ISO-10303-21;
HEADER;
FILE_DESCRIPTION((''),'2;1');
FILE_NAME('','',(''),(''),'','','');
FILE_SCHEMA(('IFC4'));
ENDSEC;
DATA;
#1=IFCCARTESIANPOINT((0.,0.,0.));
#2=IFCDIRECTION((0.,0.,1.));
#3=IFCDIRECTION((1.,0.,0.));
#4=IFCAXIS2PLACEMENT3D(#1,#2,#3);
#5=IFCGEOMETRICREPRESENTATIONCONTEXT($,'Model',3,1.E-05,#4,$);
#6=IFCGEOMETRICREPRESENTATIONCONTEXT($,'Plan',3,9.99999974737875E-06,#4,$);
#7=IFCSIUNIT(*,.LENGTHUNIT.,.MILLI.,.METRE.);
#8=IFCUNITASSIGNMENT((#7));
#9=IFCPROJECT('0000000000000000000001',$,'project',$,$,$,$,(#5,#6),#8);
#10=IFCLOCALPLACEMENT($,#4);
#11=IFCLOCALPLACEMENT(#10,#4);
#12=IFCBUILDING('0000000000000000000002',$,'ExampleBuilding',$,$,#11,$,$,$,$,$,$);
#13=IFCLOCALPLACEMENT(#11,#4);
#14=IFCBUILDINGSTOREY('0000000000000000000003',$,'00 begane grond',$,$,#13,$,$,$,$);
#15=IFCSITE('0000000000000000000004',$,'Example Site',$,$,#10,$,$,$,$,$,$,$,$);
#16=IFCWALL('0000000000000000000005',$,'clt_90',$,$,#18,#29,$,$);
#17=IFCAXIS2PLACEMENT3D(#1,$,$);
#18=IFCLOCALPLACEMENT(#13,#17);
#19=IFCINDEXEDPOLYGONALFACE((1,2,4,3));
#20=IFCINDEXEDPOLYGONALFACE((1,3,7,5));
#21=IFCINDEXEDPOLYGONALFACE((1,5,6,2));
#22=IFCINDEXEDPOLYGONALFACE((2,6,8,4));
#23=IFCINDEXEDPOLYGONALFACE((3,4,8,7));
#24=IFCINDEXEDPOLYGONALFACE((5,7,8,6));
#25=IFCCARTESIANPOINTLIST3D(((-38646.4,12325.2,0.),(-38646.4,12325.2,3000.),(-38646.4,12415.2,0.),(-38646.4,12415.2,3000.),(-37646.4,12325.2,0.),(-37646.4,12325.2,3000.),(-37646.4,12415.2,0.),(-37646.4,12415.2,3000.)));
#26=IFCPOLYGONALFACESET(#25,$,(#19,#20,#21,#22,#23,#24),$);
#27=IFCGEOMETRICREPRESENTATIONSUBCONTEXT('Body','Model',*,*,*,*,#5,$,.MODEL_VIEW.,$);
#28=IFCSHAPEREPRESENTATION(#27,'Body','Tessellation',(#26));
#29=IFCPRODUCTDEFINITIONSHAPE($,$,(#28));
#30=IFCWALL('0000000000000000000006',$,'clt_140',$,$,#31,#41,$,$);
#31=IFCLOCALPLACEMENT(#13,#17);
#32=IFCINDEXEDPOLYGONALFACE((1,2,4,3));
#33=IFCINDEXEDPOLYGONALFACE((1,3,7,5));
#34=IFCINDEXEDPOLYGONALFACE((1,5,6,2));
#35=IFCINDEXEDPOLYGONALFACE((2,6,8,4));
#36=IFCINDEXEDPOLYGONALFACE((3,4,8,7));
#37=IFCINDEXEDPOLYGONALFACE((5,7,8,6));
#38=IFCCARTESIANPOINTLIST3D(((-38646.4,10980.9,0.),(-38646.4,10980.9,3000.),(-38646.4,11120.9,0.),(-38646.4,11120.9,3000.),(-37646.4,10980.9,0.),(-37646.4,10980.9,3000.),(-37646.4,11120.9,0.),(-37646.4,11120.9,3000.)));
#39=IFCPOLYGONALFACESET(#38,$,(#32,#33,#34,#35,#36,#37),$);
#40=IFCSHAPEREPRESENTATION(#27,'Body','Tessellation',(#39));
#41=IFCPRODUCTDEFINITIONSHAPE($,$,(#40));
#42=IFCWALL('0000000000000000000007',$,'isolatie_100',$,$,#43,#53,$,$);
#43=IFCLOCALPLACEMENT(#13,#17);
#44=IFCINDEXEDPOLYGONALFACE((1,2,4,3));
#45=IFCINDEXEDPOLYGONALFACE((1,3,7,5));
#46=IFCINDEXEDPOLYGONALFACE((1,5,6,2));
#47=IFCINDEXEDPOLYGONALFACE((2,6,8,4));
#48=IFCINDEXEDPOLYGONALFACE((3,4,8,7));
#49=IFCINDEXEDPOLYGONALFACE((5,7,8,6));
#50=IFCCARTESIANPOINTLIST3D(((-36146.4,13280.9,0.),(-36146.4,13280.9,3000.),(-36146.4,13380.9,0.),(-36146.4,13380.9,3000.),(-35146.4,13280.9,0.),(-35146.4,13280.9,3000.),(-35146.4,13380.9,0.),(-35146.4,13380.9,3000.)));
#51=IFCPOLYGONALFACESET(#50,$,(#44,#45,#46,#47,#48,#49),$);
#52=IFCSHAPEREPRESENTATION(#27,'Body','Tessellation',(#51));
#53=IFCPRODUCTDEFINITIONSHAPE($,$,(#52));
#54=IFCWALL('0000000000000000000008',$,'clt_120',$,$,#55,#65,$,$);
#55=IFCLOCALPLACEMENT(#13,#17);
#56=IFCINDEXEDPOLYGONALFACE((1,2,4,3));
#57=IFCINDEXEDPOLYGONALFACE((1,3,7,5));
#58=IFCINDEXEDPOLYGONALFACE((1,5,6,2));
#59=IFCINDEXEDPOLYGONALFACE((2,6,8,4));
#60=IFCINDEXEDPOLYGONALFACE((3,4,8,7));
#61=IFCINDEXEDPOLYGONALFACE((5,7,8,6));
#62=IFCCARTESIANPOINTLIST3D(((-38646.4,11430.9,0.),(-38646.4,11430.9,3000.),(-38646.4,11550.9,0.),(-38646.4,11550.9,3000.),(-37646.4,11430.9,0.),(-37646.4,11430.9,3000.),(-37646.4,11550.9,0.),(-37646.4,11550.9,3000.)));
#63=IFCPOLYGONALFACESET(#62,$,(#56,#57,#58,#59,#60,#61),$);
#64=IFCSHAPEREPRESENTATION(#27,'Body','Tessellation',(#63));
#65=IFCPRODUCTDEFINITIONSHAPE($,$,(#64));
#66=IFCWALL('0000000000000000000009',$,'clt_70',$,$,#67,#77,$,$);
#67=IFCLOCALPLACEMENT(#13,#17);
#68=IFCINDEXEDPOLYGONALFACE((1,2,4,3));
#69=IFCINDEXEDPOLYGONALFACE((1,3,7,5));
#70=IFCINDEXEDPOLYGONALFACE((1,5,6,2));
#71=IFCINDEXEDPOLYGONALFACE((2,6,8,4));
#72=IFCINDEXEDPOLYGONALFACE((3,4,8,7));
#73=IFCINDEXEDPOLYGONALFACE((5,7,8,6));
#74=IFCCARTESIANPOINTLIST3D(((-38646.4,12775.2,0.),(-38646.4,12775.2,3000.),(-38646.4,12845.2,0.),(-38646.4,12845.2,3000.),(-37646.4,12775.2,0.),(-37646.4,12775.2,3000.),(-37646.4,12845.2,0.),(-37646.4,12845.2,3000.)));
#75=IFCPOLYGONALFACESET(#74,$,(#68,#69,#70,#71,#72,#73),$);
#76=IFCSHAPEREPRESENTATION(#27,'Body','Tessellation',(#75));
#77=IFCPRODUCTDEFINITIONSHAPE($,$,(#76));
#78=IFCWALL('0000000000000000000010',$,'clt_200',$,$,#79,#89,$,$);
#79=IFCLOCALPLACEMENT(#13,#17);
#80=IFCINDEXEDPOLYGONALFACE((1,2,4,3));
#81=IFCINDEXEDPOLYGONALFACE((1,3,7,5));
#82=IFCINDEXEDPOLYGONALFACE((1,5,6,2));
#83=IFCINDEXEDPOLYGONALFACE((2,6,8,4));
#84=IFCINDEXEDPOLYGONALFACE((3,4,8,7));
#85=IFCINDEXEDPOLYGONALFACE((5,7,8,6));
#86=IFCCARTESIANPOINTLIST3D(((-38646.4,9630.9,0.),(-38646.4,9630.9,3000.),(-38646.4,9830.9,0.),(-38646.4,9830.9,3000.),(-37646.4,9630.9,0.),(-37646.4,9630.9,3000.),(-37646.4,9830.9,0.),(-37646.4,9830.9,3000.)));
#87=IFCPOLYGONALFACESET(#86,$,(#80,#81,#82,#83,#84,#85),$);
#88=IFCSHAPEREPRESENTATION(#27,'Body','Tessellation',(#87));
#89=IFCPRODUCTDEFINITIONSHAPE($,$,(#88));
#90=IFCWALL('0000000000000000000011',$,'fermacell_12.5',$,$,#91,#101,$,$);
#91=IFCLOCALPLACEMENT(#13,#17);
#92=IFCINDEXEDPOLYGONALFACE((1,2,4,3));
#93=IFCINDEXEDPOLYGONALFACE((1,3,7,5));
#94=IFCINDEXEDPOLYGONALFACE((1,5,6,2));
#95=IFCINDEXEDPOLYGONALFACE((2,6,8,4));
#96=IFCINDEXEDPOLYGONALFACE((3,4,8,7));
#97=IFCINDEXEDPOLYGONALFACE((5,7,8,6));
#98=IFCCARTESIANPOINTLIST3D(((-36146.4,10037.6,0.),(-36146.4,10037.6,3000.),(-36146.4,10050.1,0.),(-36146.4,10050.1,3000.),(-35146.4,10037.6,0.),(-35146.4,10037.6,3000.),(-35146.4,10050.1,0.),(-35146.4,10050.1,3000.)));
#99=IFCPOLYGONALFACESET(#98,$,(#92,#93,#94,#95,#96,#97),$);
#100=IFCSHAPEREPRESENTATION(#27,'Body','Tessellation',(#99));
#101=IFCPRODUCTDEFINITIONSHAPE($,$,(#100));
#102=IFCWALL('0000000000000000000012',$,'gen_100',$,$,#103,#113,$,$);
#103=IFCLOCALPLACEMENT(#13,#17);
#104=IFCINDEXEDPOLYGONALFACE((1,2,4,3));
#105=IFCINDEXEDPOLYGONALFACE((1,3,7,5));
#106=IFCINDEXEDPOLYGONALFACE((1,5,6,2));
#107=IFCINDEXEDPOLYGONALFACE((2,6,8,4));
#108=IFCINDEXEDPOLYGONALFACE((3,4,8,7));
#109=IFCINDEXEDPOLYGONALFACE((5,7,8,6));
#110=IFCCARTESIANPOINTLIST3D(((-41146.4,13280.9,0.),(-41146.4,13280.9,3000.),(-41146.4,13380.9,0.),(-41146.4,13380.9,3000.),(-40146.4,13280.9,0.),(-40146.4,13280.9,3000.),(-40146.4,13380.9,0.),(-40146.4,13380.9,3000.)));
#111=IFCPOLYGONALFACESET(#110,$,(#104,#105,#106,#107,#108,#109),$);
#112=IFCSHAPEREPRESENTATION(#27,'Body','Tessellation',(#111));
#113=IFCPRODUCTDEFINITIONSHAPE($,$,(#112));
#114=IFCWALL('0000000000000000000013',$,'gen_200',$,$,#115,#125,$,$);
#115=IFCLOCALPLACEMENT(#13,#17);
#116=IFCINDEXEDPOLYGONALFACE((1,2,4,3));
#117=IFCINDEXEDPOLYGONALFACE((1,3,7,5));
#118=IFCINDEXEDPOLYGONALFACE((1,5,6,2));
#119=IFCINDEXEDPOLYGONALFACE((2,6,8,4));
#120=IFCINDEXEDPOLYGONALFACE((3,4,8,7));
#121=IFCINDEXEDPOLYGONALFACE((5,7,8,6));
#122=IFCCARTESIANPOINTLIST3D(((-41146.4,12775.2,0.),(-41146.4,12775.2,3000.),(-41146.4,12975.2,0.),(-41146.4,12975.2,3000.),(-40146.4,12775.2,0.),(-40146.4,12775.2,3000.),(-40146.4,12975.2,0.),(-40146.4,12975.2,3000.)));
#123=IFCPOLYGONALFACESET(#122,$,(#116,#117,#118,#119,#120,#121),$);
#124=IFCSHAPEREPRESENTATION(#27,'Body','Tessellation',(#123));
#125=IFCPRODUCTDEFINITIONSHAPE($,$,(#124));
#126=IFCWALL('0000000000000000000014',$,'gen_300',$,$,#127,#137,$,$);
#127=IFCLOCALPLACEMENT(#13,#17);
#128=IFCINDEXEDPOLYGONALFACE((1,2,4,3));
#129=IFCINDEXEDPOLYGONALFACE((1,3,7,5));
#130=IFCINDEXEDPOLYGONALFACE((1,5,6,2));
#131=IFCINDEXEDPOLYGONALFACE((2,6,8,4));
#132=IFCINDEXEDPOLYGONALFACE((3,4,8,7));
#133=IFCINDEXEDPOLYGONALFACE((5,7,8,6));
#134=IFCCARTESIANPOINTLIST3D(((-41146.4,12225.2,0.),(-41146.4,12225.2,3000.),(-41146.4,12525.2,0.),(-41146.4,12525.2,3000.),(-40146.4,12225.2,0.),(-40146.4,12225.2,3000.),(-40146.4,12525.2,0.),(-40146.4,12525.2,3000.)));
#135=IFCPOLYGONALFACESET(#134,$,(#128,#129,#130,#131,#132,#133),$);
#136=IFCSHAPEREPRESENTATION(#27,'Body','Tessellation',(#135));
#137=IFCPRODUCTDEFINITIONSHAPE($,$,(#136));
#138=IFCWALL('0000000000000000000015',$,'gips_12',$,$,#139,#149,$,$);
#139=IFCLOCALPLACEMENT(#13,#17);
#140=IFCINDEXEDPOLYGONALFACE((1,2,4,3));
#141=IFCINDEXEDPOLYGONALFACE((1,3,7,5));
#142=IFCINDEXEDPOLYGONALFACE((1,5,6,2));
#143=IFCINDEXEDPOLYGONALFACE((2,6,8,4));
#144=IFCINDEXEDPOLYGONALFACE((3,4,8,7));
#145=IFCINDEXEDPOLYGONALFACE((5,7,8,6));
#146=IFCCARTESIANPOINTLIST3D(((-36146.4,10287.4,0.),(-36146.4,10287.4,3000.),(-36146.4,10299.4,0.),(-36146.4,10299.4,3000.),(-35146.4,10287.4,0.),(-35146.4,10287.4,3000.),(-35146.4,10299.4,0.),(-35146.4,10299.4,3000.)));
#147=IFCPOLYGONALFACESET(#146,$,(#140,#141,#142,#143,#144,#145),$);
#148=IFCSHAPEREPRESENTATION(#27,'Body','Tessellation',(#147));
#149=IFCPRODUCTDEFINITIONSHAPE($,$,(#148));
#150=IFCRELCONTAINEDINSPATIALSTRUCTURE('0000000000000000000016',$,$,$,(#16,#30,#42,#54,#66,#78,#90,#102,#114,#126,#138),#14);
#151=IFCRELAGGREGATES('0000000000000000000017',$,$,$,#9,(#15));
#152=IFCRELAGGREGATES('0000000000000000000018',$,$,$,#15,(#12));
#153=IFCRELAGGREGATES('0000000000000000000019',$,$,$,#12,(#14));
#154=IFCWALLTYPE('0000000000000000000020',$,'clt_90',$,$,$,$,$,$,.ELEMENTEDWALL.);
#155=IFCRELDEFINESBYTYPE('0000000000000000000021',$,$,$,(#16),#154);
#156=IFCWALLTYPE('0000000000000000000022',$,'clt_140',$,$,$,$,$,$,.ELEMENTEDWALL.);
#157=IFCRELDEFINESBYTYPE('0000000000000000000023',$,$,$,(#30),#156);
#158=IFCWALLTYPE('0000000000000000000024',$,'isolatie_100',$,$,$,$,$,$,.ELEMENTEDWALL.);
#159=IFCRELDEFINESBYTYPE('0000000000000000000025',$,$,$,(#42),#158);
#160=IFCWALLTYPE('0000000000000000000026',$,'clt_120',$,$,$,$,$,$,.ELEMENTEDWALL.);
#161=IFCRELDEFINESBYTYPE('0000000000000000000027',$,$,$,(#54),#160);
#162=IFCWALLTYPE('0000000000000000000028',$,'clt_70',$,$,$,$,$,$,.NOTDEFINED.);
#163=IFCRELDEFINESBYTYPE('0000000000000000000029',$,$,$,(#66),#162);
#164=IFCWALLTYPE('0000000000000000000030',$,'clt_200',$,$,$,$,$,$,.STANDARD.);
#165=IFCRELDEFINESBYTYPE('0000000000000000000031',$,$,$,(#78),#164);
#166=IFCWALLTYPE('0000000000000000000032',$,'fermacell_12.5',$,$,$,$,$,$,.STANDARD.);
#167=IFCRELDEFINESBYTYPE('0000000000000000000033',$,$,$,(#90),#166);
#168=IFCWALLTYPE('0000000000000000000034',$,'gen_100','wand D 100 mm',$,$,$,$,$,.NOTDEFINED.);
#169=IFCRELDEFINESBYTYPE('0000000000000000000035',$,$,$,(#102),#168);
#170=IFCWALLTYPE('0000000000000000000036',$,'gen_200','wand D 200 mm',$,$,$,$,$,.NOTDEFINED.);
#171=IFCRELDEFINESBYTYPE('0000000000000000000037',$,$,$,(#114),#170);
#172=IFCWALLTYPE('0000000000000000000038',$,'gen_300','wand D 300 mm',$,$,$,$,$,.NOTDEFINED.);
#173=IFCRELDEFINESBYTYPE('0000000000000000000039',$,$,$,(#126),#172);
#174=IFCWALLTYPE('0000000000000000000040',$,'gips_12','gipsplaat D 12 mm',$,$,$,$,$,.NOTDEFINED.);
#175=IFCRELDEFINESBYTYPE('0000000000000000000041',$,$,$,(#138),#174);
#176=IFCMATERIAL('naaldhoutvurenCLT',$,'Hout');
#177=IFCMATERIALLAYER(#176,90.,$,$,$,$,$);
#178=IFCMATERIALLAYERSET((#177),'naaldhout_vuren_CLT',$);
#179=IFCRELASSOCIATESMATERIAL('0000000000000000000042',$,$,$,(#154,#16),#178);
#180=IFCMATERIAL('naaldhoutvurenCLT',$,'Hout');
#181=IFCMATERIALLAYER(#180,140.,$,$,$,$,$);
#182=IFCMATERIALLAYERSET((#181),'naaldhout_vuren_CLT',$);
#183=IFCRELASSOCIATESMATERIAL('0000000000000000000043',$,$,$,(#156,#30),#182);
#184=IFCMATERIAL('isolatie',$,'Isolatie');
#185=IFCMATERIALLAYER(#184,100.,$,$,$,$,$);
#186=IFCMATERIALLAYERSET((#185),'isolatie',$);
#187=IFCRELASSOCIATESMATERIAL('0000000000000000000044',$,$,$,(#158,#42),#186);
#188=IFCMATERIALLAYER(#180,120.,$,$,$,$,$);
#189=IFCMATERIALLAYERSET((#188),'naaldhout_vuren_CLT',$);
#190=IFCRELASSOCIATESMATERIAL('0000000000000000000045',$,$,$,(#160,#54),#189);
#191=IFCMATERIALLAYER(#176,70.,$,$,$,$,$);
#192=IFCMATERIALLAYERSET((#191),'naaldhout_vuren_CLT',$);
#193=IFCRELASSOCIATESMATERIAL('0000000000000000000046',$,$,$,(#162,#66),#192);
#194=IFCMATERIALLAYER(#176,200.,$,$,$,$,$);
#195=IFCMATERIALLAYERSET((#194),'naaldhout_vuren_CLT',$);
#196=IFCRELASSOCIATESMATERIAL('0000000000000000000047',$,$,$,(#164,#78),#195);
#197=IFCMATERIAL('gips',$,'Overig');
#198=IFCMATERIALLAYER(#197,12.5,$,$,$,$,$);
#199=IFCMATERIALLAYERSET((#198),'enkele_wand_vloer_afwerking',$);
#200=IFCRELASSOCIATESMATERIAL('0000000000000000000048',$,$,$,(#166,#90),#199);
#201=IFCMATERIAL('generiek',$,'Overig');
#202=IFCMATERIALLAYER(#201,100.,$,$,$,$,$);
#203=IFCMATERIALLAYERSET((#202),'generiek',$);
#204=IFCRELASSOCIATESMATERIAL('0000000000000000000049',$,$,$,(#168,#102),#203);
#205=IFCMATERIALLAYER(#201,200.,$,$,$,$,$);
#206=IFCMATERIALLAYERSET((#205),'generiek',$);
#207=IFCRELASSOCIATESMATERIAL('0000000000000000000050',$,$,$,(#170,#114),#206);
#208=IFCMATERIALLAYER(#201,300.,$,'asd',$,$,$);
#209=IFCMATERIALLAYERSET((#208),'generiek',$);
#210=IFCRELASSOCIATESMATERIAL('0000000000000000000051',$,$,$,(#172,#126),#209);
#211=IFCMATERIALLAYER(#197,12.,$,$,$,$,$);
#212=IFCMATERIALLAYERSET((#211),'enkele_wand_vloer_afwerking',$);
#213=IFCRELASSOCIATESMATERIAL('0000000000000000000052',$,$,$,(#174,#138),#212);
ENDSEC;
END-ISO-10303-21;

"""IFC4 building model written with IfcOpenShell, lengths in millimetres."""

from ifc_helpers import new_model, si_unit, frame, origin_with_axes, place, context, subcontext, project, spatial, indexed_curve, outline, extrude, material, layer, layer_set, layer_usage, type_object, element, save


model = new_model("IFC4")

# Units and contexts
model_context = context("Model", 3, precision=1e-05, world=origin_with_axes())
plan_context = context("Plan", 3, precision=9.99999974737875e-06, world=origin_with_axes())
body_context = subcontext(model_context, "Body", "Model", "MODEL_VIEW")
ifc_project = project(units=[si_unit("LENGTHUNIT", "METRE", prefix="MILLI")], contexts=[model_context, plan_context])

# Site, building, storey
site_placement = place(None, frame((0.0, 0.0, 0.0), z_axis=(0.0, 0.0, 1.0), x_axis=(1.0, 0.0, 0.0)))
site = spatial("IfcSite", under=ifc_project, at=site_placement, Name="Example Site")
building_placement = place(site_placement, frame((0.0, 0.0, 0.0), z_axis=(0.0, 0.0, 1.0), x_axis=(1.0, 0.0, 0.0)))
building = spatial("IfcBuilding", under=site, at=building_placement, Name="ExampleBuilding")
storey_placement = place(building_placement, frame((0.0, 0.0, 0.0), z_axis=(0.0, 0.0, 1.0), x_axis=(1.0, 0.0, 0.0)))
storey = spatial("IfcBuildingStorey", under=building, at=storey_placement, Name="00 begane grond")

# Walls
ifc_material_1 = material(Name="naaldhoutvurenCLT", Category="Hout")
ifc_layer_1 = layer(ifc_material_1, 90.0)
ifc_layer_set_1 = layer_set([ifc_layer_1], Name="naaldhout_vuren_CLT")
ifc_layer_usage_1 = layer_usage(ifc_layer_set_1, "AXIS2", "POSITIVE", 0.0)
wall_type_1 = type_object("IfcWallType", Name="clt_90", PredefinedType="ELEMENTEDWALL", material=ifc_layer_set_1)
wall_1_placement = place(storey_placement, frame((-38646.4, 12325.2, 0.0), z_axis=(0.0, 0.0, 1.0), x_axis=(1.0, 0.0, 0.0)))
element("IfcWall", 1, at=wall_1_placement, inside=storey, type_object=wall_type_1, material=ifc_layer_usage_1, Name="clt_90", context=body_context, shape_type="SweptSolid", body=[
    extrude(outline(indexed_curve([(0.0, 0.0), (0.0, 90.0), (1000.0, 90.0), (1000.0, 0.0), (0.0, 0.0)], self_intersect=False)), origin_with_axes(), (0.0, 0.0, 1.0), 3000.0),
])
ifc_material_2 = material(Name="naaldhoutvurenCLT", Category="Hout")
ifc_layer_2 = layer(ifc_material_2, 140.0)
ifc_layer_set_2 = layer_set([ifc_layer_2], Name="naaldhout_vuren_CLT")
ifc_layer_usage_2 = layer_usage(ifc_layer_set_2, "AXIS2", "POSITIVE", 0.0)
wall_type_2 = type_object("IfcWallType", Name="clt_140", PredefinedType="ELEMENTEDWALL", material=ifc_layer_set_2)
wall_2_placement = place(storey_placement, frame((-38646.4, 10980.9, 0.0), z_axis=(0.0, 0.0, 1.0), x_axis=(1.0, 0.0, 0.0)))
element("IfcWall", 2, at=wall_2_placement, inside=storey, type_object=wall_type_2, material=ifc_layer_usage_2, Name="clt_140", context=body_context, shape_type="SweptSolid", body=[
    extrude(outline(indexed_curve([(0.0, 0.0), (0.0, 140.0), (1000.0, 140.0), (1000.0, 0.0), (0.0, 0.0)], self_intersect=False)), origin_with_axes(), (0.0, 0.0, 1.0), 3000.0),
])
ifc_material_3 = material(Name="isolatie", Category="Isolatie")
ifc_layer_3 = layer(ifc_material_3, 100.0)
ifc_layer_set_3 = layer_set([ifc_layer_3], Name="isolatie")
ifc_layer_usage_3 = layer_usage(ifc_layer_set_3, "AXIS2", "POSITIVE", 0.0)
wall_type_3 = type_object("IfcWallType", Name="isolatie_100", PredefinedType="ELEMENTEDWALL", material=ifc_layer_set_3)
wall_3_placement = place(storey_placement, frame((-36146.4, 13280.9, 0.0), z_axis=(0.0, 0.0, 1.0), x_axis=(1.0, 0.0, 0.0)))
element("IfcWall", 3, at=wall_3_placement, inside=storey, type_object=wall_type_3, material=ifc_layer_usage_3, Name="isolatie_100", context=body_context, shape_type="SweptSolid", body=[
    extrude(outline(indexed_curve([(0.0, 0.0), (0.0, 100.0), (1000.0, 100.0), (1000.0, 0.0), (0.0, 0.0)], self_intersect=False)), origin_with_axes(), (0.0, 0.0, 1.0), 3000.0),
])
ifc_layer_4 = layer(ifc_material_2, 120.0)
ifc_layer_set_4 = layer_set([ifc_layer_4], Name="naaldhout_vuren_CLT")
ifc_layer_usage_4 = layer_usage(ifc_layer_set_4, "AXIS2", "POSITIVE", 0.0)
wall_type_4 = type_object("IfcWallType", Name="clt_120", PredefinedType="ELEMENTEDWALL", material=ifc_layer_set_4)
wall_4_placement = place(storey_placement, frame((-38646.4, 11430.9, 0.0), z_axis=(0.0, 0.0, 1.0), x_axis=(1.0, 0.0, 0.0)))
element("IfcWall", 4, at=wall_4_placement, inside=storey, type_object=wall_type_4, material=ifc_layer_usage_4, Name="clt_120", context=body_context, shape_type="SweptSolid", body=[
    extrude(outline(indexed_curve([(0.0, 0.0), (0.0, 120.0), (1000.0, 120.0), (1000.0, 0.0), (0.0, 0.0)], self_intersect=False)), origin_with_axes(), (0.0, 0.0, 1.0), 3000.0),
])
ifc_layer_5 = layer(ifc_material_1, 70.0)
ifc_layer_set_5 = layer_set([ifc_layer_5], Name="naaldhout_vuren_CLT")
ifc_layer_usage_5 = layer_usage(ifc_layer_set_5, "AXIS2", "POSITIVE", 0.0)
wall_type_5 = type_object("IfcWallType", Name="clt_70", PredefinedType="NOTDEFINED", material=ifc_layer_set_5)
wall_5_placement = place(storey_placement, frame((-38646.4, 12775.2, 0.0), z_axis=(0.0, 0.0, 1.0), x_axis=(1.0, 0.0, 0.0)))
element("IfcWall", 5, at=wall_5_placement, inside=storey, type_object=wall_type_5, material=ifc_layer_usage_5, Name="clt_70", context=body_context, shape_type="SweptSolid", body=[
    extrude(outline(indexed_curve([(0.0, 0.0), (0.0, 70.0), (1000.0, 70.0), (1000.0, 0.0), (0.0, 0.0)], self_intersect=False)), origin_with_axes(), (0.0, 0.0, 1.0), 3000.0),
])
ifc_layer_6 = layer(ifc_material_1, 200.0)
ifc_layer_set_6 = layer_set([ifc_layer_6], Name="naaldhout_vuren_CLT")
ifc_layer_usage_6 = layer_usage(ifc_layer_set_6, "AXIS2", "POSITIVE", 0.0)
wall_type_6 = type_object("IfcWallType", Name="clt_200", PredefinedType="STANDARD", material=ifc_layer_set_6)
wall_6_placement = place(storey_placement, frame((-38646.4, 9630.9, 0.0), z_axis=(0.0, 0.0, 1.0), x_axis=(1.0, 0.0, 0.0)))
element("IfcWall", 6, at=wall_6_placement, inside=storey, type_object=wall_type_6, material=ifc_layer_usage_6, Name="clt_200", context=body_context, shape_type="SweptSolid", body=[
    extrude(outline(indexed_curve([(0.0, 0.0), (0.0, 200.0), (1000.0, 200.0), (1000.0, 0.0), (0.0, 0.0)], self_intersect=False)), origin_with_axes(), (0.0, 0.0, 1.0), 3000.0),
])
ifc_material_4 = material(Name="gips", Category="Overig")
ifc_layer_7 = layer(ifc_material_4, 12.5)
ifc_layer_set_7 = layer_set([ifc_layer_7], Name="enkele_wand_vloer_afwerking")
ifc_layer_usage_7 = layer_usage(ifc_layer_set_7, "AXIS2", "POSITIVE", 0.0)
wall_type_7 = type_object("IfcWallType", Name="fermacell_12.5", PredefinedType="STANDARD", material=ifc_layer_set_7)
wall_7_placement = place(storey_placement, frame((-36146.4, 10037.6, 0.0), z_axis=(0.0, 0.0, 1.0), x_axis=(1.0, 0.0, 0.0)))
element("IfcWall", 7, at=wall_7_placement, inside=storey, type_object=wall_type_7, material=ifc_layer_usage_7, Name="fermacell_12.5", context=body_context, shape_type="SweptSolid", body=[
    extrude(outline(indexed_curve([(0.0, 0.0), (0.0, 12.5), (1000.0, 12.5), (1000.0, 0.0), (0.0, 0.0)], self_intersect=False)), origin_with_axes(), (0.0, 0.0, 1.0), 3000.0),
])
ifc_material_5 = material(Name="generiek", Category="Overig")
ifc_layer_8 = layer(ifc_material_5, 100.0)
ifc_layer_set_8 = layer_set([ifc_layer_8], Name="generiek")
ifc_layer_usage_8 = layer_usage(ifc_layer_set_8, "AXIS2", "POSITIVE", 0.0)
wall_type_8 = type_object("IfcWallType", Name="gen_100", Description="wand D 100 mm", PredefinedType="NOTDEFINED", material=ifc_layer_set_8)
wall_8_placement = place(storey_placement, frame((-41146.4, 13280.9, 0.0), z_axis=(0.0, 0.0, 1.0), x_axis=(1.0, 0.0, 0.0)))
element("IfcWall", 8, at=wall_8_placement, inside=storey, type_object=wall_type_8, material=ifc_layer_usage_8, Name="gen_100", context=body_context, shape_type="SweptSolid", body=[
    extrude(outline(indexed_curve([(0.0, 0.0), (0.0, 100.0), (1000.0, 100.0), (1000.0, 0.0), (0.0, 0.0)], self_intersect=False)), origin_with_axes(), (0.0, 0.0, 1.0), 3000.0),
])
ifc_layer_9 = layer(ifc_material_5, 200.0)
ifc_layer_set_9 = layer_set([ifc_layer_9], Name="generiek")
ifc_layer_usage_9 = layer_usage(ifc_layer_set_9, "AXIS2", "POSITIVE", 0.0)
wall_type_9 = type_object("IfcWallType", Name="gen_200", Description="wand D 200 mm", PredefinedType="NOTDEFINED", material=ifc_layer_set_9)
wall_9_placement = place(storey_placement, frame((-41146.4, 12775.2, 0.0), z_axis=(0.0, 0.0, 1.0), x_axis=(1.0, 0.0, 0.0)))
element("IfcWall", 9, at=wall_9_placement, inside=storey, type_object=wall_type_9, material=ifc_layer_usage_9, Name="gen_200", context=body_context, shape_type="SweptSolid", body=[
    extrude(outline(indexed_curve([(0.0, 0.0), (0.0, 200.0), (1000.0, 200.0), (1000.0, 0.0), (0.0, 0.0)], self_intersect=False)), origin_with_axes(), (0.0, 0.0, 1.0), 3000.0),
])
ifc_layer_10 = layer(ifc_material_5, 300.0, Name="asd")
ifc_layer_set_10 = layer_set([ifc_layer_10], Name="generiek")
ifc_layer_usage_10 = layer_usage(ifc_layer_set_10, "AXIS2", "POSITIVE", 0.0)
wall_type_10 = type_object("IfcWallType", Name="gen_300", Description="wand D 300 mm", PredefinedType="NOTDEFINED", material=ifc_layer_set_10)
wall_10_placement = place(storey_placement, frame((-41146.4, 12225.2, 0.0), z_axis=(0.0, 0.0, 1.0), x_axis=(1.0, 0.0, 0.0)))
element("IfcWall", 10, at=wall_10_placement, inside=storey, type_object=wall_type_10, material=ifc_layer_usage_10, Name="gen_300", context=body_context, shape_type="SweptSolid", body=[
    extrude(outline(indexed_curve([(0.0, 0.0), (0.0, 300.0), (1000.0, 300.0), (1000.0, 0.0), (0.0, 0.0)], self_intersect=False)), origin_with_axes(), (0.0, 0.0, 1.0), 3000.0),
])
ifc_layer_11 = layer(ifc_material_4, 12.0)
ifc_layer_set_11 = layer_set([ifc_layer_11], Name="enkele_wand_vloer_afwerking")
ifc_layer_usage_11 = layer_usage(ifc_layer_set_11, "AXIS2", "POSITIVE", 0.0)
wall_type_11 = type_object("IfcWallType", Name="gips_12", Description="gipsplaat D 12 mm", PredefinedType="NOTDEFINED", material=ifc_layer_set_11)
wall_11_placement = place(storey_placement, frame((-36146.4, 10287.4, 0.0), z_axis=(0.0, 0.0, 1.0), x_axis=(1.0, 0.0, 0.0)))
element("IfcWall", 11, at=wall_11_placement, inside=storey, type_object=wall_type_11, material=ifc_layer_usage_11, Name="gips_12", context=body_context, shape_type="SweptSolid", body=[
    extrude(outline(indexed_curve([(0.0, 0.0), (0.0, 12.0), (1000.0, 12.0), (1000.0, 0.0), (0.0, 0.0)], self_intersect=False)), origin_with_axes(), (0.0, 0.0, 1.0), 3000.0),
])

save(model, "model.ifc")
